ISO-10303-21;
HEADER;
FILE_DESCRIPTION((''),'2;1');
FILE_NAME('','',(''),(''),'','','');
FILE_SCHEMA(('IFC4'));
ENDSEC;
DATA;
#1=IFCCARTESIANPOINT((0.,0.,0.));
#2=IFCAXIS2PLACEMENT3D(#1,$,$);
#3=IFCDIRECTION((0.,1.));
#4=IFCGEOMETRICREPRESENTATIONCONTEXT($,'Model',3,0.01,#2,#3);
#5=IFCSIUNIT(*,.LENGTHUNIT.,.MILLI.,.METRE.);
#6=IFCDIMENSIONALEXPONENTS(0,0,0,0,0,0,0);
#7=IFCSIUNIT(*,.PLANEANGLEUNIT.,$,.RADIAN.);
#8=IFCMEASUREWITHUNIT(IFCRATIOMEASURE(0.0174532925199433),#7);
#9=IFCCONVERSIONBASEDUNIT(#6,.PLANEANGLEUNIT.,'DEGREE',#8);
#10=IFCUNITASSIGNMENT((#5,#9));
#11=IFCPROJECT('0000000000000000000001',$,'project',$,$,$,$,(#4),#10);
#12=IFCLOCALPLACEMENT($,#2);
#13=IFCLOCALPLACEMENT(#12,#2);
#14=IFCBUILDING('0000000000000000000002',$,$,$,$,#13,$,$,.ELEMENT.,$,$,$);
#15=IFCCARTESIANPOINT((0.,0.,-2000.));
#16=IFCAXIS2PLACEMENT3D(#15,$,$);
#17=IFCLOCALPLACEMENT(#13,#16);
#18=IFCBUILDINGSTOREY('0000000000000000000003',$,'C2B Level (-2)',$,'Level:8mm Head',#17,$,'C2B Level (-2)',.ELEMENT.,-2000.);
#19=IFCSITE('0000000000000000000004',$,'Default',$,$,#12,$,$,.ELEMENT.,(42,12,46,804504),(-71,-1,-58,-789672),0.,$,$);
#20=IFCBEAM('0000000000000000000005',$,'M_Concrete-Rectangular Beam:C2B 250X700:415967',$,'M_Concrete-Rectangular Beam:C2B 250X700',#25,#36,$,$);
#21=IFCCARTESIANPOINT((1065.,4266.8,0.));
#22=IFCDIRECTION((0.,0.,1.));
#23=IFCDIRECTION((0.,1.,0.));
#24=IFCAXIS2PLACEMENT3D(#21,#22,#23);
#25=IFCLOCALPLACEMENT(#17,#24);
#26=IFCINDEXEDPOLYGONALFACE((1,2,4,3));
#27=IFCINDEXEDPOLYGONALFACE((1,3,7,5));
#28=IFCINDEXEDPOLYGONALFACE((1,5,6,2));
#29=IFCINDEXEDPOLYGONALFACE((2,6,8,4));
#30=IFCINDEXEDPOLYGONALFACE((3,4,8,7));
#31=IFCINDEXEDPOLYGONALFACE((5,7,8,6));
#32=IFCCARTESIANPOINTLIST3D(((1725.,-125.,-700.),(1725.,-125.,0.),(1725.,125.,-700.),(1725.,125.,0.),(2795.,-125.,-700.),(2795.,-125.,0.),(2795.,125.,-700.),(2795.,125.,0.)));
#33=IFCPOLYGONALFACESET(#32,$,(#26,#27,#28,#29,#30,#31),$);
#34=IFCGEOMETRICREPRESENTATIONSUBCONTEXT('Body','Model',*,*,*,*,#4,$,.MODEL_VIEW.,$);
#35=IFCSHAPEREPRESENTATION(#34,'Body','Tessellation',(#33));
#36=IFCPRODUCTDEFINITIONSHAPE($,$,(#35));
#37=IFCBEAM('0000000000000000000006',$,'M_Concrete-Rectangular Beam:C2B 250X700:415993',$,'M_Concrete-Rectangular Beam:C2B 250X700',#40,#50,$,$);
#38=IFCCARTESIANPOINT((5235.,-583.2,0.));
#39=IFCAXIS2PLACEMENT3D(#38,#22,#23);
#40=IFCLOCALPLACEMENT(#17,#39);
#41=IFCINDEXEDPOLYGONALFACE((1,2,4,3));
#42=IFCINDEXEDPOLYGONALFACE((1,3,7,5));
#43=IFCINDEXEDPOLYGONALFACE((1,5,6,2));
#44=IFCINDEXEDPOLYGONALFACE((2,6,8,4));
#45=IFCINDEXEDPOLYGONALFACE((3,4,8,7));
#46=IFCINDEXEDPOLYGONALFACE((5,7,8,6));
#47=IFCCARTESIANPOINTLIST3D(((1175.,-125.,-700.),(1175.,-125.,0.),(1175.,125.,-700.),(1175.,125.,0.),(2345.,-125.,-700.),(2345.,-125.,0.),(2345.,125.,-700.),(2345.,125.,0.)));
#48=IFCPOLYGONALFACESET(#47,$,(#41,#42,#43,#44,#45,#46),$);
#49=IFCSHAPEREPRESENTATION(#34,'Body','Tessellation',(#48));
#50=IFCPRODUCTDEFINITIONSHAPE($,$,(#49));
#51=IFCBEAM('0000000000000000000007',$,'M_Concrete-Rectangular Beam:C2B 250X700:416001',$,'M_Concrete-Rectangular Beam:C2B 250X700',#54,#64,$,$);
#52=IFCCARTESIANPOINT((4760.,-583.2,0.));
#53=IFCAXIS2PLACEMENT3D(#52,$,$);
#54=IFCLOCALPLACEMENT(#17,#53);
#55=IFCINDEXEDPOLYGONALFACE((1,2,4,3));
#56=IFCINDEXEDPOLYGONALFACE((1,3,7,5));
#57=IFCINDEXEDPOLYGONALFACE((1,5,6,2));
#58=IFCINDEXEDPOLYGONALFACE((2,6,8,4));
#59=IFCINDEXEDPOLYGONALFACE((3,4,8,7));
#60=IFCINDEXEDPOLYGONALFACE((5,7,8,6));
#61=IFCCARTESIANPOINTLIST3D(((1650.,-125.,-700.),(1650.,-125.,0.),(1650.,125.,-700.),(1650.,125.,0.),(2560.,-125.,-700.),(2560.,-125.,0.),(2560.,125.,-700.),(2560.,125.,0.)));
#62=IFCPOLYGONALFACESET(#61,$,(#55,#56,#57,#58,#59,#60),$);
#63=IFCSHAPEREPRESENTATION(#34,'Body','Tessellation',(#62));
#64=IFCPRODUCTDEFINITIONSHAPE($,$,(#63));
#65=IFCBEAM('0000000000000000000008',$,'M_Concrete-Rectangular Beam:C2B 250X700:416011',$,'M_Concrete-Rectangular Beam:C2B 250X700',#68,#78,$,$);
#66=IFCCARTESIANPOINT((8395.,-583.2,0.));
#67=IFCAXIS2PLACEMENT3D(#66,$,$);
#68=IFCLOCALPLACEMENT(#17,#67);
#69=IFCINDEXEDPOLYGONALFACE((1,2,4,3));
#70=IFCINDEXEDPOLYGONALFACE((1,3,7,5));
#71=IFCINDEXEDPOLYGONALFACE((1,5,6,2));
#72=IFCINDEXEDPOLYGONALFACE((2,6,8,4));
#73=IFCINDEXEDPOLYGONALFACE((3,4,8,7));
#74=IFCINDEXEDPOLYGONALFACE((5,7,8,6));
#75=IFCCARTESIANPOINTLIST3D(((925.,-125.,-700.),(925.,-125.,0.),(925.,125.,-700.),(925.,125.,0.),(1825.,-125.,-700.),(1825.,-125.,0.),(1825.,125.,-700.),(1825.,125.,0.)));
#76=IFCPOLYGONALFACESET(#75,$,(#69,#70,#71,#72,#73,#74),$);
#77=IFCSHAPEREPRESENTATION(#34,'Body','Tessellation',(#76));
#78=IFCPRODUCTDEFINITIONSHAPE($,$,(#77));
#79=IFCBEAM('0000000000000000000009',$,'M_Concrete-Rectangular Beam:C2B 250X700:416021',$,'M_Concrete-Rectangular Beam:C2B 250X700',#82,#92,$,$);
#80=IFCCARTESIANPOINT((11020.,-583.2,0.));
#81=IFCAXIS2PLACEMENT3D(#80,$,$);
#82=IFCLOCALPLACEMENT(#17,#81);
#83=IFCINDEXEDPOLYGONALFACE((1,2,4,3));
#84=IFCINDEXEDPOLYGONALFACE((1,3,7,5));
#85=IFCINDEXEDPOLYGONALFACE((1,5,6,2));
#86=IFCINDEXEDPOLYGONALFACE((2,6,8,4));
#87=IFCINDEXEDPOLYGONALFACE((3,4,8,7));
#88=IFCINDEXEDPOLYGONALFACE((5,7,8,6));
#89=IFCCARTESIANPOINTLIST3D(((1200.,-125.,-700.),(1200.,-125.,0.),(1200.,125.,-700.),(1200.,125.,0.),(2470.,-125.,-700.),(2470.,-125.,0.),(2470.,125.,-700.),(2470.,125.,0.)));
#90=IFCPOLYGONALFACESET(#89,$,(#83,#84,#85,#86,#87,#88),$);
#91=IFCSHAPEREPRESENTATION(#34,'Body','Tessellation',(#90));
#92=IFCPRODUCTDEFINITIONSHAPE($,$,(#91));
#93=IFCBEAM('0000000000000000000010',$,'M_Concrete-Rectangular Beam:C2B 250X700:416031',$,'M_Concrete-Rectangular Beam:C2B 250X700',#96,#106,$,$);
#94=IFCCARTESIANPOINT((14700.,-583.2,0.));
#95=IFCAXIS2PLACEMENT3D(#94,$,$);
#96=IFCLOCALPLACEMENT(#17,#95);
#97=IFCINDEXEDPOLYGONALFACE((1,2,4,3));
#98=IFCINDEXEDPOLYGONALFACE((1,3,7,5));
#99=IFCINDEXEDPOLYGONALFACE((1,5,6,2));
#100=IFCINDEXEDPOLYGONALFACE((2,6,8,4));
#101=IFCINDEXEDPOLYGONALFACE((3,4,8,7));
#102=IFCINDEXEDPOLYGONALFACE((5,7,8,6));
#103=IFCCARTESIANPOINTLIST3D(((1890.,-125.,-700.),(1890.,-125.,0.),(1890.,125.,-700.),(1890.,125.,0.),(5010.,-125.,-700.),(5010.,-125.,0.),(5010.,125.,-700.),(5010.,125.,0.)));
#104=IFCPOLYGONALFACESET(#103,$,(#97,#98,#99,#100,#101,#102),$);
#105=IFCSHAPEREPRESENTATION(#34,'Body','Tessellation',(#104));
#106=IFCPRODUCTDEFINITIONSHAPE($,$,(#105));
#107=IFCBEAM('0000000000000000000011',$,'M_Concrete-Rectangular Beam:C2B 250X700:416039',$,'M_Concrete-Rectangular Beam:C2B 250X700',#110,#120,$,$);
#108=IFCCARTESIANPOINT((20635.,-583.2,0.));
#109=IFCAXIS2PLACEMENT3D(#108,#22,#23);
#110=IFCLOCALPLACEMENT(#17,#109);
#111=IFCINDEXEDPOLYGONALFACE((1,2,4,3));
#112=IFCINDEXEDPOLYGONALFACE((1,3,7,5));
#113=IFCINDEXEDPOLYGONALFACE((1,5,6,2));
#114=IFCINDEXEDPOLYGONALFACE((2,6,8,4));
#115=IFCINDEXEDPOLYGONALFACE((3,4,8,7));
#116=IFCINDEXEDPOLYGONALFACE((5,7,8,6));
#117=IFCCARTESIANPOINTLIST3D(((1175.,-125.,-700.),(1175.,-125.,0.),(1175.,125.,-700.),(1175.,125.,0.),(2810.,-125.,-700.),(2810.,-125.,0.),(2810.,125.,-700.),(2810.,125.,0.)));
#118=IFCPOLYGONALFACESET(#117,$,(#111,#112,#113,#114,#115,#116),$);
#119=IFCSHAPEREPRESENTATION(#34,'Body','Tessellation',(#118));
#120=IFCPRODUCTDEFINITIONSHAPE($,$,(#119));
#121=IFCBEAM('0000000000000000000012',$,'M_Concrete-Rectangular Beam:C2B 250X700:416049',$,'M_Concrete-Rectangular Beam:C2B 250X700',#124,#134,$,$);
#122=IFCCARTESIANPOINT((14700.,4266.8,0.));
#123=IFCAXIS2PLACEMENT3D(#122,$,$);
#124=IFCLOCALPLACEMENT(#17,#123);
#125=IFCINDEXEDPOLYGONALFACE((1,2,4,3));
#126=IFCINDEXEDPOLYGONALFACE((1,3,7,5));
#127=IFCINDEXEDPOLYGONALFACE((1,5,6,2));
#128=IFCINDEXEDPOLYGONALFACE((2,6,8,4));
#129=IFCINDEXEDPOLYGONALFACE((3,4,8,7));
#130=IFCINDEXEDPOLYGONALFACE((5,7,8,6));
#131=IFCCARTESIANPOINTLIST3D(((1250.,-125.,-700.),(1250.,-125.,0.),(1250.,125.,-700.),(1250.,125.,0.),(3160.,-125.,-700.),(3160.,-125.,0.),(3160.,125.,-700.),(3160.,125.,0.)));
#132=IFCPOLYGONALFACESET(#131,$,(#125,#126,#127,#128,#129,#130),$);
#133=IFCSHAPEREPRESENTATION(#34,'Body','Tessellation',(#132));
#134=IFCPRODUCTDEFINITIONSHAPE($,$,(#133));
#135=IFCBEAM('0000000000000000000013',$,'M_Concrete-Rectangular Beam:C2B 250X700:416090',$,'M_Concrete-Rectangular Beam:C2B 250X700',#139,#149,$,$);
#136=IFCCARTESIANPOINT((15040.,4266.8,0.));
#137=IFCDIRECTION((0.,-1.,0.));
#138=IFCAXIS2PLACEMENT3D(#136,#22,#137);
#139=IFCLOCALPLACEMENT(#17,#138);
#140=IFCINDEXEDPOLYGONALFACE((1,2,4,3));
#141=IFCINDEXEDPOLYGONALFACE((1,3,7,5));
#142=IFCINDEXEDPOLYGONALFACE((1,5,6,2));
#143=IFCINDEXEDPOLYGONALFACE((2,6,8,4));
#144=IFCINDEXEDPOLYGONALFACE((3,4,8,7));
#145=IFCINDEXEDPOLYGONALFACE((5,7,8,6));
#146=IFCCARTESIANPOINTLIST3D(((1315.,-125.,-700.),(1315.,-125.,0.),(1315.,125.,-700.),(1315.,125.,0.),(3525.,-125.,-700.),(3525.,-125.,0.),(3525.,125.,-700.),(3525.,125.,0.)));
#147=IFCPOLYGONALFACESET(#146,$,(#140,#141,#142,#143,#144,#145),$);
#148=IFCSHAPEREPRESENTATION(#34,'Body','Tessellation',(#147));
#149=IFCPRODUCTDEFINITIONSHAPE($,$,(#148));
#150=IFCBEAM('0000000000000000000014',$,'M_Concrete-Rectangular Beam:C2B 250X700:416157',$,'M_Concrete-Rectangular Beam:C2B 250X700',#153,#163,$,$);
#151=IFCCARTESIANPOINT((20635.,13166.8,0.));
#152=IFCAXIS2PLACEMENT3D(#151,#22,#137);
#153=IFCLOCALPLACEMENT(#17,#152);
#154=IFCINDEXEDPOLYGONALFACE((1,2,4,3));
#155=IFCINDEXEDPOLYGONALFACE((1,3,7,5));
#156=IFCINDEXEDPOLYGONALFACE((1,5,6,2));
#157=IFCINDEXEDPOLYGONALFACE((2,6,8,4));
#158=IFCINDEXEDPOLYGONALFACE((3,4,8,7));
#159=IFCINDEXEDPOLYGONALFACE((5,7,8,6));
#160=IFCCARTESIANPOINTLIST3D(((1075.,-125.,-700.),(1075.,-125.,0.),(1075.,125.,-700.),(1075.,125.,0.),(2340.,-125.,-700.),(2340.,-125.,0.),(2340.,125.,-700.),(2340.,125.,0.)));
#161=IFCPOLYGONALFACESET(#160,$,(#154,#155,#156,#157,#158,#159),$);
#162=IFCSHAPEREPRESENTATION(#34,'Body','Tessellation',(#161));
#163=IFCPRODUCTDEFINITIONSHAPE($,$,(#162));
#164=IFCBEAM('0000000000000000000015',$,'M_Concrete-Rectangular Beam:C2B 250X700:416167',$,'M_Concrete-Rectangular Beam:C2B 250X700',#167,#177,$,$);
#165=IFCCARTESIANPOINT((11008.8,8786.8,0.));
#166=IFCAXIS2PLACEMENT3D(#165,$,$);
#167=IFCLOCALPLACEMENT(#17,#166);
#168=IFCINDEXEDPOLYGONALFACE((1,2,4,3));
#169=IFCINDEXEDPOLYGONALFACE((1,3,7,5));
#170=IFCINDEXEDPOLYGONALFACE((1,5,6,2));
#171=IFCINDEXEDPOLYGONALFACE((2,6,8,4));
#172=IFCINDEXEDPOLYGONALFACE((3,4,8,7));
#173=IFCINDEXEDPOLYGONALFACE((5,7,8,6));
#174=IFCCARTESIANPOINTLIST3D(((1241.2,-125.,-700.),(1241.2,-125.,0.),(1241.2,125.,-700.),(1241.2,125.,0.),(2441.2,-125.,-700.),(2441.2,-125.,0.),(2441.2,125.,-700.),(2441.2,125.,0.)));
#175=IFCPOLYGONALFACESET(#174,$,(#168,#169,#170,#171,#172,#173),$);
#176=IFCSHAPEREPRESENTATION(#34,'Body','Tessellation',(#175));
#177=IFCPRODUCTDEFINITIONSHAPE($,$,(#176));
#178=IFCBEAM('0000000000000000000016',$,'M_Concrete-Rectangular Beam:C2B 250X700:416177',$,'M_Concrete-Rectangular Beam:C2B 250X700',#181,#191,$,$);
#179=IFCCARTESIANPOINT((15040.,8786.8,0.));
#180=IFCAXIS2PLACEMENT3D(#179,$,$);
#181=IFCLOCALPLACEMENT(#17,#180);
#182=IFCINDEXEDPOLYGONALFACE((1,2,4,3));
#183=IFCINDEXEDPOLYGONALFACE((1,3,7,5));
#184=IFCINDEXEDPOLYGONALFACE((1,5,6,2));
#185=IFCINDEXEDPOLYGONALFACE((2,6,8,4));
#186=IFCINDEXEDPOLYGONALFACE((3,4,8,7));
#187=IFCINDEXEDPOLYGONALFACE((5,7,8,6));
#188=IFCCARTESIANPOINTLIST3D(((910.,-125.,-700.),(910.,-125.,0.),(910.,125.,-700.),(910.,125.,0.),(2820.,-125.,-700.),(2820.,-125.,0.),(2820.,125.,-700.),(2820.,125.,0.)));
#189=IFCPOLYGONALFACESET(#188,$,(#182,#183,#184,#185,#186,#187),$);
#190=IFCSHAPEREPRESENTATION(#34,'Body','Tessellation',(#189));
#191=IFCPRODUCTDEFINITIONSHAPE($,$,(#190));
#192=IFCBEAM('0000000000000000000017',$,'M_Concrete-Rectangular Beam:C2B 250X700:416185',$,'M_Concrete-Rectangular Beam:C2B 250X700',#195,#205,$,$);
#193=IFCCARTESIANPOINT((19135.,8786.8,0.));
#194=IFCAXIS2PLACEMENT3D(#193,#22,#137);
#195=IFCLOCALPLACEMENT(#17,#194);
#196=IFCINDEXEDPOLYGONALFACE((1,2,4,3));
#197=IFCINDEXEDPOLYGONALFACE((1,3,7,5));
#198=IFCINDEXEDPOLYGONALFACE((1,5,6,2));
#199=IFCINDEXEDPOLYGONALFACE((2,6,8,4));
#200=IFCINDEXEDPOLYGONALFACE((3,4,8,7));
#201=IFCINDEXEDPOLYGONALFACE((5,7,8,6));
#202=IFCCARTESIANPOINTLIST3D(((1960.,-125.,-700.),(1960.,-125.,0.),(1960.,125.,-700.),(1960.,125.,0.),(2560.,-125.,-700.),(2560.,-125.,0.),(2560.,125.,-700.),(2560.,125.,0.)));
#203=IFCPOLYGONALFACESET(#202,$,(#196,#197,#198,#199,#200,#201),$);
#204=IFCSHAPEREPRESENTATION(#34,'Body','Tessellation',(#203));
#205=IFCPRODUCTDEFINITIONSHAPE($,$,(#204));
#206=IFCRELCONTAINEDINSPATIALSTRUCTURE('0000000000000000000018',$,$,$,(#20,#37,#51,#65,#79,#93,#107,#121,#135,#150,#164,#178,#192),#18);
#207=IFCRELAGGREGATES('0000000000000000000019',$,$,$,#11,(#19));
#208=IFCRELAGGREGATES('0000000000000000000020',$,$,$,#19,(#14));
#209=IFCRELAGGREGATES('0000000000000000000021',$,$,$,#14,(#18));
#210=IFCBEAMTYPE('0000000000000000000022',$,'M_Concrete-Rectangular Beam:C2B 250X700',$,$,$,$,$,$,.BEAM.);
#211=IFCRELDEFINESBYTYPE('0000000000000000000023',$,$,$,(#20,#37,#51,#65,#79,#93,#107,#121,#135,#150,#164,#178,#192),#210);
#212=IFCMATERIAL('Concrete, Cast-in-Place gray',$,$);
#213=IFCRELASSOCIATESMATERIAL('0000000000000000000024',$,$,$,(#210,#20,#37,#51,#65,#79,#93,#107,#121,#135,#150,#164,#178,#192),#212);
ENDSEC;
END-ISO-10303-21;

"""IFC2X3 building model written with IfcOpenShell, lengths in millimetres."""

from ifc_helpers import new_model, entity, si_unit, converted_unit, direction, frame, frame_2d, origin, place, context, subcontext, project, spatial, rectangle, extrude, material, type_object, element, save


model = new_model("IFC2X3")

# Units and contexts
model_context = context("Model", 3, precision=0.01, world=origin(), true_north=direction((0.0, 1.0)))
body_context = subcontext(model_context, "Body", "Model", "MODEL_VIEW")
ifc_project = project(units=[si_unit("LENGTHUNIT", "METRE", prefix="MILLI"), converted_unit("PLANEANGLEUNIT", "DEGREE", entity("IfcRatioMeasure", 0.0174532925199433), si_unit("PLANEANGLEUNIT", "RADIAN"), dimensions=[0, 0, 0, 0, 0, 0, 0])], contexts=[model_context])

# Site, building, storey
site_placement = place(None, origin())
site = spatial("IfcSite", under=ifc_project, at=site_placement, Name="Default", CompositionType="ELEMENT", RefLatitude=(42, 12, 46, 804504), RefLongitude=(-71, -1, -58, -789672), RefElevation=0.0)
building_placement = place(site_placement, origin())
building = spatial("IfcBuilding", under=site, at=building_placement, CompositionType="ELEMENT")
storey_placement = place(building_placement, frame((0.0, 0.0, -2000.0)))
storey = spatial("IfcBuildingStorey", under=building, at=storey_placement, Name="C2B Level (-2)", ObjectType="Level:8mm Head", LongName="C2B Level (-2)", CompositionType="ELEMENT", Elevation=-2000.0)

# Beams
ifc_material = material(Name="Concrete, Cast-in-Place gray")
beam_type = type_object("IfcBeamType", Name="M_Concrete-Rectangular Beam:C2B 250X700", PredefinedType="BEAM", material=ifc_material)
beam_1_placement = place(storey_placement, frame((1065.0, 4266.8, 0.0), z_axis=(0.0, 0.0, 1.0), x_axis=(0.0, 1.0, 0.0)))
element("IfcBeam", 1, at=beam_1_placement, inside=storey, type_object=beam_type, material=ifc_material, Name="M_Concrete-Rectangular Beam:C2B 250X700:415967", ObjectType="M_Concrete-Rectangular Beam:C2B 250X700", context=body_context, shape_type="SweptSolid", body=[
    extrude(rectangle(XDim=700.0, YDim=250.0, at=frame_2d((0.0, 0.0), x_axis=(1.0, 0.0))), frame((1725.0, 0.0, -350.0), z_axis=(1.0, 0.0, 0.0), x_axis=(0.0, 0.0, -1.0)), (0.0, 0.0, 1.0), 1070.0),
])
beam_2_placement = place(storey_placement, frame((5235.0, -583.2, 0.0), z_axis=(0.0, 0.0, 1.0), x_axis=(0.0, 1.0, 0.0)))
element("IfcBeam", 2, at=beam_2_placement, inside=storey, type_object=beam_type, material=ifc_material, Name="M_Concrete-Rectangular Beam:C2B 250X700:415993", ObjectType="M_Concrete-Rectangular Beam:C2B 250X700", context=body_context, shape_type="SweptSolid", body=[
    extrude(rectangle(XDim=700.0, YDim=250.0, at=frame_2d((0.0, 0.0), x_axis=(1.0, 0.0))), frame((1175.0, 0.0, -350.0), z_axis=(1.0, 0.0, 0.0), x_axis=(0.0, 0.0, -1.0)), (0.0, 0.0, 1.0), 1170.0),
])
beam_3_placement = place(storey_placement, frame((4760.0, -583.2, 0.0)))
element("IfcBeam", 3, at=beam_3_placement, inside=storey, type_object=beam_type, material=ifc_material, Name="M_Concrete-Rectangular Beam:C2B 250X700:416001", ObjectType="M_Concrete-Rectangular Beam:C2B 250X700", context=body_context, shape_type="SweptSolid", body=[
    extrude(rectangle(XDim=700.0, YDim=250.0, at=frame_2d((0.0, 0.0), x_axis=(1.0, 0.0))), frame((1650.0, 0.0, -350.0), z_axis=(1.0, 0.0, 0.0), x_axis=(0.0, 0.0, -1.0)), (0.0, 0.0, 1.0), 910.0),
])
beam_4_placement = place(storey_placement, frame((8395.0, -583.2, 0.0)))
element("IfcBeam", 4, at=beam_4_placement, inside=storey, type_object=beam_type, material=ifc_material, Name="M_Concrete-Rectangular Beam:C2B 250X700:416011", ObjectType="M_Concrete-Rectangular Beam:C2B 250X700", context=body_context, shape_type="SweptSolid", body=[
    extrude(rectangle(XDim=700.0, YDim=250.0, at=frame_2d((0.0, 0.0), x_axis=(1.0, 0.0))), frame((925.0, 0.0, -350.0), z_axis=(1.0, 0.0, 0.0), x_axis=(0.0, 0.0, -1.0)), (0.0, 0.0, 1.0), 900.0),
])
beam_5_placement = place(storey_placement, frame((11020.0, -583.2, 0.0)))
element("IfcBeam", 5, at=beam_5_placement, inside=storey, type_object=beam_type, material=ifc_material, Name="M_Concrete-Rectangular Beam:C2B 250X700:416021", ObjectType="M_Concrete-Rectangular Beam:C2B 250X700", context=body_context, shape_type="SweptSolid", body=[
    extrude(rectangle(XDim=700.0, YDim=250.0, at=frame_2d((0.0, 0.0), x_axis=(1.0, 0.0))), frame((1200.0, 0.0, -350.0), z_axis=(1.0, 0.0, 0.0), x_axis=(0.0, 0.0, -1.0)), (0.0, 0.0, 1.0), 1270.0),
])
beam_6_placement = place(storey_placement, frame((14700.0, -583.2, 0.0)))
element("IfcBeam", 6, at=beam_6_placement, inside=storey, type_object=beam_type, material=ifc_material, Name="M_Concrete-Rectangular Beam:C2B 250X700:416031", ObjectType="M_Concrete-Rectangular Beam:C2B 250X700", context=body_context, shape_type="SweptSolid", body=[
    extrude(rectangle(XDim=700.0, YDim=250.0, at=frame_2d((0.0, 0.0), x_axis=(1.0, 0.0))), frame((1890.0, 0.0, -350.0), z_axis=(1.0, 0.0, 0.0), x_axis=(0.0, 0.0, -1.0)), (0.0, 0.0, 1.0), 3120.0),
])
beam_7_placement = place(storey_placement, frame((20635.0, -583.2, 0.0), z_axis=(0.0, 0.0, 1.0), x_axis=(0.0, 1.0, 0.0)))
element("IfcBeam", 7, at=beam_7_placement, inside=storey, type_object=beam_type, material=ifc_material, Name="M_Concrete-Rectangular Beam:C2B 250X700:416039", ObjectType="M_Concrete-Rectangular Beam:C2B 250X700", context=body_context, shape_type="SweptSolid", body=[
    extrude(rectangle(XDim=700.0, YDim=250.0, at=frame_2d((0.0, 0.0), x_axis=(1.0, 0.0))), frame((1175.0, 0.0, -350.0), z_axis=(1.0, 0.0, 0.0), x_axis=(0.0, 0.0, -1.0)), (0.0, 0.0, 1.0), 1635.0),
])
beam_8_placement = place(storey_placement, frame((14700.0, 4266.8, 0.0)))
element("IfcBeam", 8, at=beam_8_placement, inside=storey, type_object=beam_type, material=ifc_material, Name="M_Concrete-Rectangular Beam:C2B 250X700:416049", ObjectType="M_Concrete-Rectangular Beam:C2B 250X700", context=body_context, shape_type="SweptSolid", body=[
    extrude(rectangle(XDim=700.0, YDim=250.0, at=frame_2d((0.0, 0.0), x_axis=(1.0, 0.0))), frame((1250.0, 0.0, -350.0), z_axis=(1.0, 0.0, 0.0), x_axis=(0.0, 0.0, -1.0)), (0.0, 0.0, 1.0), 1910.0),
])
beam_9_placement = place(storey_placement, frame((15040.0, 4266.8, 0.0), z_axis=(0.0, 0.0, 1.0), x_axis=(0.0, -1.0, 0.0)))
element("IfcBeam", 9, at=beam_9_placement, inside=storey, type_object=beam_type, material=ifc_material, Name="M_Concrete-Rectangular Beam:C2B 250X700:416090", ObjectType="M_Concrete-Rectangular Beam:C2B 250X700", context=body_context, shape_type="SweptSolid", body=[
    extrude(rectangle(XDim=700.0, YDim=250.0, at=frame_2d((0.0, 0.0), x_axis=(1.0, 0.0))), frame((1315.0, 0.0, -350.0), z_axis=(1.0, 0.0, 0.0), x_axis=(0.0, 0.0, -1.0)), (0.0, 0.0, 1.0), 2210.0),
])
beam_10_placement = place(storey_placement, frame((20635.0, 13166.8, 0.0), z_axis=(0.0, 0.0, 1.0), x_axis=(0.0, -1.0, 0.0)))
element("IfcBeam", 10, at=beam_10_placement, inside=storey, type_object=beam_type, material=ifc_material, Name="M_Concrete-Rectangular Beam:C2B 250X700:416157", ObjectType="M_Concrete-Rectangular Beam:C2B 250X700", context=body_context, shape_type="SweptSolid", body=[
    extrude(rectangle(XDim=700.0, YDim=250.0, at=frame_2d((0.0, 0.0), x_axis=(1.0, 0.0))), frame((1075.0, 0.0, -350.0), z_axis=(1.0, 0.0, 0.0), x_axis=(0.0, 0.0, -1.0)), (0.0, 0.0, 1.0), 1265.0),
])
beam_11_placement = place(storey_placement, frame((11008.8, 8786.8, 0.0)))
element("IfcBeam", 11, at=beam_11_placement, inside=storey, type_object=beam_type, material=ifc_material, Name="M_Concrete-Rectangular Beam:C2B 250X700:416167", ObjectType="M_Concrete-Rectangular Beam:C2B 250X700", context=body_context, shape_type="SweptSolid", body=[
    extrude(rectangle(XDim=700.0, YDim=250.0, at=frame_2d((0.0, 0.0), x_axis=(1.0, 0.0))), frame((1241.2, 0.0, -350.0), z_axis=(1.0, 0.0, 0.0), x_axis=(0.0, 0.0, -1.0)), (0.0, 0.0, 1.0), 1200.0),
])
beam_12_placement = place(storey_placement, frame((15040.0, 8786.8, 0.0)))
element("IfcBeam", 12, at=beam_12_placement, inside=storey, type_object=beam_type, material=ifc_material, Name="M_Concrete-Rectangular Beam:C2B 250X700:416177", ObjectType="M_Concrete-Rectangular Beam:C2B 250X700", context=body_context, shape_type="SweptSolid", body=[
    extrude(rectangle(XDim=700.0, YDim=250.0, at=frame_2d((0.0, 0.0), x_axis=(1.0, 0.0))), frame((910.0, 0.0, -350.0), z_axis=(1.0, 0.0, 0.0), x_axis=(0.0, 0.0, -1.0)), (0.0, 0.0, 1.0), 1910.0),
])
beam_13_placement = place(storey_placement, frame((19135.0, 8786.8, 0.0), z_axis=(0.0, 0.0, 1.0), x_axis=(0.0, -1.0, 0.0)))
element("IfcBeam", 13, at=beam_13_placement, inside=storey, type_object=beam_type, material=ifc_material, Name="M_Concrete-Rectangular Beam:C2B 250X700:416185", ObjectType="M_Concrete-Rectangular Beam:C2B 250X700", context=body_context, shape_type="SweptSolid", body=[
    extrude(rectangle(XDim=700.0, YDim=250.0, at=frame_2d((0.0, 0.0), x_axis=(1.0, 0.0))), frame((1960.0, 0.0, -350.0), z_axis=(1.0, 0.0, 0.0), x_axis=(0.0, 0.0, -1.0)), (0.0, 0.0, 1.0), 600.0),
])

save(model, "model.ifc")
